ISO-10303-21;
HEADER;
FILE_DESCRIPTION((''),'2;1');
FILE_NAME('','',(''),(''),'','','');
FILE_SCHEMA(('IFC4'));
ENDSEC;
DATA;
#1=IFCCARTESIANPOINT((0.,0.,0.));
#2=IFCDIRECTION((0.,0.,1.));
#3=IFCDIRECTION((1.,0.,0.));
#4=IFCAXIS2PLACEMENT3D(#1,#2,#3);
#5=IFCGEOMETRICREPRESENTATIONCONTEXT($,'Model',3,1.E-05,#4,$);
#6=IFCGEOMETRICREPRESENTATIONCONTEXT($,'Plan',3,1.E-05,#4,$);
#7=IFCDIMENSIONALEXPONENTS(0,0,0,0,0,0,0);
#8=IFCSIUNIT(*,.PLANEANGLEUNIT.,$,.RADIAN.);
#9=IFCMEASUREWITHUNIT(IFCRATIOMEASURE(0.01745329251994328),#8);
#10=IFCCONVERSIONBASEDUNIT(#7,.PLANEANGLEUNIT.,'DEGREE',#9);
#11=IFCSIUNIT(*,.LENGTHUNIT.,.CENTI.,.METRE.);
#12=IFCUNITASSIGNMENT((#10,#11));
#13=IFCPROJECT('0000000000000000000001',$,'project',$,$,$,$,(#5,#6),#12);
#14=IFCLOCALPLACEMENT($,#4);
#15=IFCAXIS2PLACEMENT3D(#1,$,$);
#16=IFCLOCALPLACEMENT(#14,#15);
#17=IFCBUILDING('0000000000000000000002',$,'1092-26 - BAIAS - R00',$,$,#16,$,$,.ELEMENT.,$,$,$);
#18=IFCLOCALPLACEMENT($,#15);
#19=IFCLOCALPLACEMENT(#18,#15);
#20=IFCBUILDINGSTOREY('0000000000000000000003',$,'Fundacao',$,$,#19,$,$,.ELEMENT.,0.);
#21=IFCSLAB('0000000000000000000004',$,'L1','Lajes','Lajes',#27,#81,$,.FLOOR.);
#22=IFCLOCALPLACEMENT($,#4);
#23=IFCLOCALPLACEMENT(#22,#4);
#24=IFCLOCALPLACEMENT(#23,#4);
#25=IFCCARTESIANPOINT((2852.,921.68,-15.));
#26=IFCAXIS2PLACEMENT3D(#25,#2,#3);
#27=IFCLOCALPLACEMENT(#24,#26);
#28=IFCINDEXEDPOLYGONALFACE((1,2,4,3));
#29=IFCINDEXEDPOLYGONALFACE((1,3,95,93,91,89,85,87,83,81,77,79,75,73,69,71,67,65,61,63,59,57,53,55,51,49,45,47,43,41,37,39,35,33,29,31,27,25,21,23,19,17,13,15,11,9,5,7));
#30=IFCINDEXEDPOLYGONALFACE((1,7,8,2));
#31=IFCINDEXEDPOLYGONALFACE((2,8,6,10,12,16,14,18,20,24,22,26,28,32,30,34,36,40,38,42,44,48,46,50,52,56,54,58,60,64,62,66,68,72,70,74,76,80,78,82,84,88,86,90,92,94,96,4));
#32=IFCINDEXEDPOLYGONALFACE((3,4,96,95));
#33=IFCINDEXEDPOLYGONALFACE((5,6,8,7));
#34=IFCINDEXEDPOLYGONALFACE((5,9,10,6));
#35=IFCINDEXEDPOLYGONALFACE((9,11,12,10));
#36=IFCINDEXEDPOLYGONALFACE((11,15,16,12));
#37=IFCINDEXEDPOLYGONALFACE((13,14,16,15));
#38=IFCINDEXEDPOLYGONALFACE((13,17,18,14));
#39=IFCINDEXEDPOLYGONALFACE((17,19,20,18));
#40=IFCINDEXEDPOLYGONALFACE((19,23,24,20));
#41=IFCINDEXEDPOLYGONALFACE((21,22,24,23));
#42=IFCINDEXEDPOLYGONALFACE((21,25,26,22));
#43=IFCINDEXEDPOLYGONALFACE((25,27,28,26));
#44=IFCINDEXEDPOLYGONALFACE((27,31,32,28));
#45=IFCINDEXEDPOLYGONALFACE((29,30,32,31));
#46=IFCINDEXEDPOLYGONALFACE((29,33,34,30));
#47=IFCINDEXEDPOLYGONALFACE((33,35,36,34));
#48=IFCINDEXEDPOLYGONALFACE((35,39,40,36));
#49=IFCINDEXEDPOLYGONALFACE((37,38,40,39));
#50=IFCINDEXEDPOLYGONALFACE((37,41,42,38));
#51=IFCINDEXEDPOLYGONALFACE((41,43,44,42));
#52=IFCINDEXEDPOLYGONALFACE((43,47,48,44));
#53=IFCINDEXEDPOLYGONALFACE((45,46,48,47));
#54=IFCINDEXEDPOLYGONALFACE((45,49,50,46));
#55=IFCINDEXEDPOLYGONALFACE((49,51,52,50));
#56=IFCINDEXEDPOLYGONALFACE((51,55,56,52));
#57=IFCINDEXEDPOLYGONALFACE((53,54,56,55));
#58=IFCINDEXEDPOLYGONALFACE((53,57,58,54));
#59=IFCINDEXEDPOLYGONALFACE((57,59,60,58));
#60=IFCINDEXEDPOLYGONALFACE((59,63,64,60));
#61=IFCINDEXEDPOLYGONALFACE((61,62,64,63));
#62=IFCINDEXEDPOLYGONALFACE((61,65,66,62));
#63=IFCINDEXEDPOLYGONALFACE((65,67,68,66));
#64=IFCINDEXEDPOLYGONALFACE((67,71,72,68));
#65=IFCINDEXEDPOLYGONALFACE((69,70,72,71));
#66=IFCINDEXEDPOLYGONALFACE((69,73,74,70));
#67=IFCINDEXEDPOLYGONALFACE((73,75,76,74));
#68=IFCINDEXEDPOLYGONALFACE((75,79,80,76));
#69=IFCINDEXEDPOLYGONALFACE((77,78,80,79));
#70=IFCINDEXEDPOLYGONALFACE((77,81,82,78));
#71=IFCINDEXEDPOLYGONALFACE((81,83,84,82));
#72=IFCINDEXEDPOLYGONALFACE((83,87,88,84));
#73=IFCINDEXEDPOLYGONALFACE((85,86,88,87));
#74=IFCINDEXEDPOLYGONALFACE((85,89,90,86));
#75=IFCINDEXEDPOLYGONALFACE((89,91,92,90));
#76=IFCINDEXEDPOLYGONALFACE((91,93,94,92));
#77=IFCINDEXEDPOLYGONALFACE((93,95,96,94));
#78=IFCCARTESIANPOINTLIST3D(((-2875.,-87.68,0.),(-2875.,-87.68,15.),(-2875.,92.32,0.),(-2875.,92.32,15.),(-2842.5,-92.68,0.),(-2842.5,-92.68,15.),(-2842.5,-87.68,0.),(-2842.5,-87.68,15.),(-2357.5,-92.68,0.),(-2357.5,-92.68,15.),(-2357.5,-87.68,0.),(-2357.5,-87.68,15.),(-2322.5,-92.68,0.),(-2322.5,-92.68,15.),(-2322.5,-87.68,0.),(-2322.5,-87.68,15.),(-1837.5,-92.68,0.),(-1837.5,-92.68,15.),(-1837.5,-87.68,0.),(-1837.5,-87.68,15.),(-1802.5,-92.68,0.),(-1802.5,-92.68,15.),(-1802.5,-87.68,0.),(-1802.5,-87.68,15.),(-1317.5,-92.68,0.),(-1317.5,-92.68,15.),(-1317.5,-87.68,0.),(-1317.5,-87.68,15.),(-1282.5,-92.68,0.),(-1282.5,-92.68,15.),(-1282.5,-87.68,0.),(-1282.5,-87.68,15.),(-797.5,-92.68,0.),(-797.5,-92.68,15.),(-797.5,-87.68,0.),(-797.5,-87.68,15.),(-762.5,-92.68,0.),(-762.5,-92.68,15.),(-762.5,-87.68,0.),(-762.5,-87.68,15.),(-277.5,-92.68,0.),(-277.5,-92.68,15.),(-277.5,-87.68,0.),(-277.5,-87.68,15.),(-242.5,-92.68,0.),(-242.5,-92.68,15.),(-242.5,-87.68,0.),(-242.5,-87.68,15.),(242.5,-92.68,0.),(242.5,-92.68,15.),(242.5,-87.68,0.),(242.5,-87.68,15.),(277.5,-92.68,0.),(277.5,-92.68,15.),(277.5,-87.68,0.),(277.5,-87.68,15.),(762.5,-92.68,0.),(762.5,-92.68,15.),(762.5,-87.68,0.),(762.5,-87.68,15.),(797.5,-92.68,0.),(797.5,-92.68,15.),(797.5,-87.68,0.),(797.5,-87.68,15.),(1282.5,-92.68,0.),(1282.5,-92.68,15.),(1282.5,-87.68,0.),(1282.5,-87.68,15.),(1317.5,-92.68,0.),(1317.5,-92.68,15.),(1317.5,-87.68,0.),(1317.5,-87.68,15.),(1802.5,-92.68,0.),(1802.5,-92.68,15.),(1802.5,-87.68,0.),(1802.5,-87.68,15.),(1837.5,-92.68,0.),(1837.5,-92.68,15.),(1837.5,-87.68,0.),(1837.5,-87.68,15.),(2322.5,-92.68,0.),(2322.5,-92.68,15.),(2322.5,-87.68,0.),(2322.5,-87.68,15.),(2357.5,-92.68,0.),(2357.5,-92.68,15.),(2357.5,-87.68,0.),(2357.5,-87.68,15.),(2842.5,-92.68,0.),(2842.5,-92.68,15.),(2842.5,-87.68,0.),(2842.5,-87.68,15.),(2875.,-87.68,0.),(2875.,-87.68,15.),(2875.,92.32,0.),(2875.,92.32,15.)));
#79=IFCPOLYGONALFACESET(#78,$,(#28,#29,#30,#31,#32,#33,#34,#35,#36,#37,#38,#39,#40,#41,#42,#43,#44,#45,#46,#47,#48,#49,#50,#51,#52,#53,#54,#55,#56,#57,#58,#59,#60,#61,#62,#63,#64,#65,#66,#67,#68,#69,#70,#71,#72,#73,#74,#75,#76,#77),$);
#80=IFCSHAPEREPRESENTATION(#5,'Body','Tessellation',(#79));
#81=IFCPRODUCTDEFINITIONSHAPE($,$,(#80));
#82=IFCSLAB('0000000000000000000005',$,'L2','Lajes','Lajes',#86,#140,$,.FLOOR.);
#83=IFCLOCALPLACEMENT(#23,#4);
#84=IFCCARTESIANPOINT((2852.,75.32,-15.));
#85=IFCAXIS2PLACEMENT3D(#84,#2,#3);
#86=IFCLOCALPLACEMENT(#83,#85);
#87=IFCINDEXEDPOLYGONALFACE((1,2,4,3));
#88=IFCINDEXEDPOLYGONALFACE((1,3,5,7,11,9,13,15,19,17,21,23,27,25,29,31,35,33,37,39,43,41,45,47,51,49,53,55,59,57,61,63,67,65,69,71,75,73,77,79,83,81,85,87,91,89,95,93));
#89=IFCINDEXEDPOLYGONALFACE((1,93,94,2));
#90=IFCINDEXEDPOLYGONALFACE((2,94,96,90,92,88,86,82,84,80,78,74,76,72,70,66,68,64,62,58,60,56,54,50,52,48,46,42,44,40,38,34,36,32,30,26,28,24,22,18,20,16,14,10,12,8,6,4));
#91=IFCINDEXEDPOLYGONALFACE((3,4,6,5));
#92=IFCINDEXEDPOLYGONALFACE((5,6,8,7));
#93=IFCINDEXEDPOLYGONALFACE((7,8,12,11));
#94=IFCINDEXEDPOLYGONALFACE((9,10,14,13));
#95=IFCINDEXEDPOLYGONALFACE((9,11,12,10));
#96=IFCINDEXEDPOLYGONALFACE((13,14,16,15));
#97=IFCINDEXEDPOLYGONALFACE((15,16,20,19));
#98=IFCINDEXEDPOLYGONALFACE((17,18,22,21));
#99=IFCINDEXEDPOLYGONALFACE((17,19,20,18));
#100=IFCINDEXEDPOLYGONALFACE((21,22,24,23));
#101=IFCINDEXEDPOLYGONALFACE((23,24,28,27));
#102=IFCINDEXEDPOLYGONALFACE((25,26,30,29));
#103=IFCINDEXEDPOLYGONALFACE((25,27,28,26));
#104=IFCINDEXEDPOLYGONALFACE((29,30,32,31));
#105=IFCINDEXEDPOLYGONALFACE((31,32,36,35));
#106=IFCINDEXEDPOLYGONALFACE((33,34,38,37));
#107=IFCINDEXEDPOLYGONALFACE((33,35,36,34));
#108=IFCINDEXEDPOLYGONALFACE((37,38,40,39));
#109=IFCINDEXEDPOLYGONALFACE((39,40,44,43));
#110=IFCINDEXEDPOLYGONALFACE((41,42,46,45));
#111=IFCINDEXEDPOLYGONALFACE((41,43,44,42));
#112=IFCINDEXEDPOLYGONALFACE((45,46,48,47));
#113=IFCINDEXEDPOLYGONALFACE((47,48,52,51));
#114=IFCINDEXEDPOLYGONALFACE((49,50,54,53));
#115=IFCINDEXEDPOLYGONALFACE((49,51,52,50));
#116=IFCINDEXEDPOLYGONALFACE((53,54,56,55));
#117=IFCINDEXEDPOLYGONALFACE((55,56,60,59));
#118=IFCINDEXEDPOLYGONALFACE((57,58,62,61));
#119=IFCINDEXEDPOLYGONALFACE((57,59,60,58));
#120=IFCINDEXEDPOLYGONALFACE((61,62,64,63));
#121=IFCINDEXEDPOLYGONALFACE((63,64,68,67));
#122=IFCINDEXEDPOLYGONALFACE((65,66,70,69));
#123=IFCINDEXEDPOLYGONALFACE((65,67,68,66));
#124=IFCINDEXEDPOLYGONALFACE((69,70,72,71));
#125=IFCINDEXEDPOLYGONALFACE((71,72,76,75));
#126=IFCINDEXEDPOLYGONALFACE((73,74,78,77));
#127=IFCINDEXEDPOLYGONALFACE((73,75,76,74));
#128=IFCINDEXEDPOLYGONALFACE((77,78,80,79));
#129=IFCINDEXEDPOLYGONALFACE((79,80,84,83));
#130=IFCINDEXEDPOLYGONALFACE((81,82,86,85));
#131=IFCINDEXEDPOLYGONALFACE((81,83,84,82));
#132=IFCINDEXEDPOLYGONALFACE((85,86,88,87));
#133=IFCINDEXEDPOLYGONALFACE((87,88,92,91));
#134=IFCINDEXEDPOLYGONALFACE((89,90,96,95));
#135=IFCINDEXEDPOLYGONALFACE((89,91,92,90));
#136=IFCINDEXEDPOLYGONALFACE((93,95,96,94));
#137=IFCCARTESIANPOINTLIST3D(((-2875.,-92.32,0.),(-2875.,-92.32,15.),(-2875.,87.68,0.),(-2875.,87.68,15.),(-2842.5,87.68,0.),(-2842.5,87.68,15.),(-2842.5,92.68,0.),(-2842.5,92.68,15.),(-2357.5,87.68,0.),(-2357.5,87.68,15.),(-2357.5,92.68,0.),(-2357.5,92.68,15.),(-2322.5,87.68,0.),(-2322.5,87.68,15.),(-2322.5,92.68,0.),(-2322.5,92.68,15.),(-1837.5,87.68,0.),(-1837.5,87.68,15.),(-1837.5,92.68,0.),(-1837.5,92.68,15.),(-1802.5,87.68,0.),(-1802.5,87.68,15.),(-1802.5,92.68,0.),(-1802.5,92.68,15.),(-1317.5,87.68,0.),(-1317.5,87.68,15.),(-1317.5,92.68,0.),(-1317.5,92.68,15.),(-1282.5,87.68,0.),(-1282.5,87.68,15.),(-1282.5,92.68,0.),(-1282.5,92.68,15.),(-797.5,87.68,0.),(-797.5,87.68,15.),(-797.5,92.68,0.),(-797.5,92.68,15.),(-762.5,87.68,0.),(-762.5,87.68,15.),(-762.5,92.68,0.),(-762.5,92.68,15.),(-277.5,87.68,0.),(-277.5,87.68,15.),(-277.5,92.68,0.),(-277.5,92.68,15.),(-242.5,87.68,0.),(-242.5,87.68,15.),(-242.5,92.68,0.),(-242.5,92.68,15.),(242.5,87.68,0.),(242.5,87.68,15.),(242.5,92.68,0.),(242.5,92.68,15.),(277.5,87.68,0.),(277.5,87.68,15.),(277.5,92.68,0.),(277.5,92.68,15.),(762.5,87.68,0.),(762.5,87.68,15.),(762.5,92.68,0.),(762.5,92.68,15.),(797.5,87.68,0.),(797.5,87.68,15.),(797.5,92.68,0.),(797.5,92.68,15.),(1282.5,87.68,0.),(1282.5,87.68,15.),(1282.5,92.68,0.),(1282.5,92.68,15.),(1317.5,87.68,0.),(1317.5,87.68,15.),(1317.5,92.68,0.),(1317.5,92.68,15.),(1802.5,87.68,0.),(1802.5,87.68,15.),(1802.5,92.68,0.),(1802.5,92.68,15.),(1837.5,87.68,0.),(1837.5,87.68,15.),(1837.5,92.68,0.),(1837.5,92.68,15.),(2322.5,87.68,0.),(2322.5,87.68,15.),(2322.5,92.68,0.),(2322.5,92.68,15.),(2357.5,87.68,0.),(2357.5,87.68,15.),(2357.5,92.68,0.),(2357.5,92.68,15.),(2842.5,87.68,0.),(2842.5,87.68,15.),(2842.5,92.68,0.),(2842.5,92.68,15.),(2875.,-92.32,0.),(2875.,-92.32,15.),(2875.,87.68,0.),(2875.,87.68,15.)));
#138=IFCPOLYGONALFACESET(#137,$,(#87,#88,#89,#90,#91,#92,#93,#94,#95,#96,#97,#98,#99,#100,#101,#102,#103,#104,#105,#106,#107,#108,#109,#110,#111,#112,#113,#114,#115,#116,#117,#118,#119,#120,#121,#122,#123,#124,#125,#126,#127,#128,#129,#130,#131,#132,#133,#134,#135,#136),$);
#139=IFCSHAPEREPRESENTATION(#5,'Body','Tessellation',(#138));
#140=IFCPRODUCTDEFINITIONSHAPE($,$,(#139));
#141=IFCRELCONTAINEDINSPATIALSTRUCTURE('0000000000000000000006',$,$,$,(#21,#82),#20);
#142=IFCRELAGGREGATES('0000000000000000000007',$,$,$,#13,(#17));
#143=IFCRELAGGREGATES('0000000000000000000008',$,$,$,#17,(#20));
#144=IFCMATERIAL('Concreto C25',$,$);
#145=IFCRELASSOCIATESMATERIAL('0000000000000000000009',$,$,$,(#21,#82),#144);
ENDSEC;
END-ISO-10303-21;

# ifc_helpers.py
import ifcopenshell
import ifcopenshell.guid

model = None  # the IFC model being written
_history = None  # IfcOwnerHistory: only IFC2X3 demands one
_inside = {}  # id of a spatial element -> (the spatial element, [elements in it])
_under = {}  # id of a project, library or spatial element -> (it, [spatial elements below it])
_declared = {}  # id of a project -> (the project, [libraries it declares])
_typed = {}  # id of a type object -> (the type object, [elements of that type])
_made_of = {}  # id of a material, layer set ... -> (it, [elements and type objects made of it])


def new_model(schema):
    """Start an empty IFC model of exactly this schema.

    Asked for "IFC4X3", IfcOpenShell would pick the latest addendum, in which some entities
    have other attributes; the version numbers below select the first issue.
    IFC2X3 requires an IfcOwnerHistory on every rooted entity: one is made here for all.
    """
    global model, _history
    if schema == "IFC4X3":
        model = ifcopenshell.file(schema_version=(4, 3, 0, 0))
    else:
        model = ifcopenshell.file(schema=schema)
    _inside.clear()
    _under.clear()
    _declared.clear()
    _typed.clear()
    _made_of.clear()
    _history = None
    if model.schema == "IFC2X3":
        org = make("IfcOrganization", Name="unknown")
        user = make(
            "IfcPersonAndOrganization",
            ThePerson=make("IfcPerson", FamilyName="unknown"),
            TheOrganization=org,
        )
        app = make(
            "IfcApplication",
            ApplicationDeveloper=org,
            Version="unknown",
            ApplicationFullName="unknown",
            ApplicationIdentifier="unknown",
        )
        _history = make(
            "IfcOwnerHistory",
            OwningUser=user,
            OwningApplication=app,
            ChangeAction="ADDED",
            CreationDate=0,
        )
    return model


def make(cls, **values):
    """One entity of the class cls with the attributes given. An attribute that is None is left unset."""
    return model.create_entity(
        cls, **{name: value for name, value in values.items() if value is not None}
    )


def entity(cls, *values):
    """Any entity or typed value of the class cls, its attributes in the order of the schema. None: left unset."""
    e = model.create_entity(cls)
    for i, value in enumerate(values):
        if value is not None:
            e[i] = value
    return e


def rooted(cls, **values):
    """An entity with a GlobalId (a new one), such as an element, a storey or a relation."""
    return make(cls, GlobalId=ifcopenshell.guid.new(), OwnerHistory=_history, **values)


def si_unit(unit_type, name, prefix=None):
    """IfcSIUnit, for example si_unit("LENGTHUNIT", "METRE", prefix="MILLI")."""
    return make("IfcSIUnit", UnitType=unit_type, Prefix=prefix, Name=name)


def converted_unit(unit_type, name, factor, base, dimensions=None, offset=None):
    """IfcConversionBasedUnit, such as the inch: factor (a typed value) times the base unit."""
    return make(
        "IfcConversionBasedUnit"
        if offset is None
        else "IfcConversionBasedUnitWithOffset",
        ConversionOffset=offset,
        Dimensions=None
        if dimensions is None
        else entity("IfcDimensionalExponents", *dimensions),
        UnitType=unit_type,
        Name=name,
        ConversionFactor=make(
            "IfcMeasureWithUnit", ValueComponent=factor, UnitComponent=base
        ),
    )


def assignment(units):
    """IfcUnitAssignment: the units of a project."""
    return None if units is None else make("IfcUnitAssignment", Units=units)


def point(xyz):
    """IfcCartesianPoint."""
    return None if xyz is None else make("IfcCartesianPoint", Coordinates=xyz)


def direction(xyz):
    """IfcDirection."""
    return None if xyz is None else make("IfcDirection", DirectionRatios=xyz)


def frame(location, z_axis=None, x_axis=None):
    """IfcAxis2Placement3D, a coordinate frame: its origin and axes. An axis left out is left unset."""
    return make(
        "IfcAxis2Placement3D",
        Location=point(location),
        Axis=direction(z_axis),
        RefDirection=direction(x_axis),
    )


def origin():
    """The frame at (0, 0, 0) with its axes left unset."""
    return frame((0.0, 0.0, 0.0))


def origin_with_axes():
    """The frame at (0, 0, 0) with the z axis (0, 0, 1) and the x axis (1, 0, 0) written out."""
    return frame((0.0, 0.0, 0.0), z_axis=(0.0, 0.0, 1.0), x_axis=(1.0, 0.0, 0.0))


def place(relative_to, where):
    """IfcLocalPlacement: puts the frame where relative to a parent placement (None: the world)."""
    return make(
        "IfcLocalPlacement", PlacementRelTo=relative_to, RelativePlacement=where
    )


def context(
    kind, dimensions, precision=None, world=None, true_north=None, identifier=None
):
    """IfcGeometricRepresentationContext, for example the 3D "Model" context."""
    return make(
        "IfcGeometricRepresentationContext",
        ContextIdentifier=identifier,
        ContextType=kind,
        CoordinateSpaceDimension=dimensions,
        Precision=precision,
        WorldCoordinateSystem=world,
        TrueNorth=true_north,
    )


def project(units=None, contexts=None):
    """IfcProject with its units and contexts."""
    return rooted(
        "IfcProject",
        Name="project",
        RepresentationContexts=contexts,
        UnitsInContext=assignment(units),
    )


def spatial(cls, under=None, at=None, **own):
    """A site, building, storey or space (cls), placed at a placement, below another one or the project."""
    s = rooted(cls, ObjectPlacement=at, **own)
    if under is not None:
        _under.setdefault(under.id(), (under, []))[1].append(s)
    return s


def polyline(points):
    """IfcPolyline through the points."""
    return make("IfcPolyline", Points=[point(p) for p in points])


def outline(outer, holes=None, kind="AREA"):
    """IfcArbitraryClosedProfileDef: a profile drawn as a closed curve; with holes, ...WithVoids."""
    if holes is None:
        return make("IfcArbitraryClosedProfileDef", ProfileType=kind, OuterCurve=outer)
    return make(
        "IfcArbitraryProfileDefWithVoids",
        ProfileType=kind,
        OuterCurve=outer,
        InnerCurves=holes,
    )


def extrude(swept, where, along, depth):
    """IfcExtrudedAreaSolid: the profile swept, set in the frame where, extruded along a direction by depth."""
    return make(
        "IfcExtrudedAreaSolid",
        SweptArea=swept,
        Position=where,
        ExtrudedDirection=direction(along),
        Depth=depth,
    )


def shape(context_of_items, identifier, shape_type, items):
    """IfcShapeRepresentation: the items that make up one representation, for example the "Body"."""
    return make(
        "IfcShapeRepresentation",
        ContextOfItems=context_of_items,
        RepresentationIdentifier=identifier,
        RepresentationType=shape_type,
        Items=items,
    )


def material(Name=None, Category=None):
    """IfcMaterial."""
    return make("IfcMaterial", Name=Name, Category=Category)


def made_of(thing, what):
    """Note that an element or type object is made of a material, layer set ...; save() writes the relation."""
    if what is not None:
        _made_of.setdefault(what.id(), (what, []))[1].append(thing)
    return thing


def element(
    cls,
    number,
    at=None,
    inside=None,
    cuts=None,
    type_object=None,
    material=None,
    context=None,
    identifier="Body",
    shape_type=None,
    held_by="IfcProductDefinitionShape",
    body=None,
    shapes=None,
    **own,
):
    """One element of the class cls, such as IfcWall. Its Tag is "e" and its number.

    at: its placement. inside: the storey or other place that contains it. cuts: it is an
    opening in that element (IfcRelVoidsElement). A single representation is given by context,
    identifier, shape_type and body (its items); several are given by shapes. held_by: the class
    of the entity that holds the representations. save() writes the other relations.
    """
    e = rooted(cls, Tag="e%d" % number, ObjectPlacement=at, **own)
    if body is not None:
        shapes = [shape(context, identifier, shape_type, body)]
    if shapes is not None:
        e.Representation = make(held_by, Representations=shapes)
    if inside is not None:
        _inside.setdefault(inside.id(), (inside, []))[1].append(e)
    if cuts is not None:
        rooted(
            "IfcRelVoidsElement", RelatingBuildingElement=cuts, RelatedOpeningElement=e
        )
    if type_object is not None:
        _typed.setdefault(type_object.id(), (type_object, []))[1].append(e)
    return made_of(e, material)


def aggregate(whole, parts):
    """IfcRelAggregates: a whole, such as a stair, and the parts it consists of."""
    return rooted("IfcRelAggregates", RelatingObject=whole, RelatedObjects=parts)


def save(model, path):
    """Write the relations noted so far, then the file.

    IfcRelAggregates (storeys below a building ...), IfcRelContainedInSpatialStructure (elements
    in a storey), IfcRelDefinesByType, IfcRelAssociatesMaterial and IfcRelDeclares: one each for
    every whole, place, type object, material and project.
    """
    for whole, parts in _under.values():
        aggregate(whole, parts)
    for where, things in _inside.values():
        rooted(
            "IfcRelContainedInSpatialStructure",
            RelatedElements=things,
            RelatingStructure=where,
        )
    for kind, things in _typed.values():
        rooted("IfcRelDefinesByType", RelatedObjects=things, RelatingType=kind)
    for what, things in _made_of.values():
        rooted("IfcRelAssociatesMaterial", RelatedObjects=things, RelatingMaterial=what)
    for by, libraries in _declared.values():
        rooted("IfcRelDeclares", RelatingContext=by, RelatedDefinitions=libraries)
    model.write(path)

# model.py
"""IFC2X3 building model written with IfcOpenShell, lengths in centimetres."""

from ifc_helpers import new_model, entity, si_unit, converted_unit, frame, origin, origin_with_axes, place, context, project, spatial, polyline, outline, extrude, material, element, save


model = new_model("IFC2X3")

# Units and contexts
model_context = context("Model", 3, precision=1e-05, world=origin_with_axes())
plan_context = context("Plan", 3, precision=1e-05, world=origin_with_axes())
ifc_project = project(units=[converted_unit("PLANEANGLEUNIT", "DEGREE", entity("IfcRatioMeasure", 0.01745329251994328), si_unit("PLANEANGLEUNIT", "RADIAN"), dimensions=[0, 0, 0, 0, 0, 0, 0]), si_unit("LENGTHUNIT", "METRE", prefix="CENTI")], contexts=[model_context, plan_context])

# Building, storey
placement_1 = place(None, origin_with_axes())
building_placement = place(placement_1, origin())
building = spatial("IfcBuilding", under=ifc_project, at=building_placement, Name="1092-26 - BAIAS - R00", CompositionType="ELEMENT")
placement_2 = place(None, origin())
storey_placement = place(placement_2, origin())
storey = spatial("IfcBuildingStorey", under=building, at=storey_placement, Name="Fundacao", CompositionType="ELEMENT", Elevation=0.0)

# Shared definitions
placement_3 = place(None, origin_with_axes())
placement_4 = place(placement_3, origin_with_axes())

# Slabs
ifc_material_1 = material(Name="Concreto C25")
placement_5 = place(placement_4, origin_with_axes())
slab_1_placement = place(placement_5, frame((2852.0, 921.68, -15.0), z_axis=(0.0, 0.0, 1.0), x_axis=(1.0, 0.0, 0.0)))
element("IfcSlab", 1, at=slab_1_placement, inside=storey, material=ifc_material_1, Name="L1", Description="Lajes", ObjectType="Lajes", PredefinedType="FLOOR", context=model_context, shape_type="SweptSolid", body=[
    extrude(outline(polyline([(-2842.5, -87.68, 0.0), (-2875.0, -87.68, 0.0), (-2875.0, 92.32, 0.0), (2875.0, 92.32, 0.0), (2875.0, -87.68, 0.0), (2842.5, -87.68, 0.0), (2842.5, -92.68, 0.0), (2357.5, -92.68, 0.0), (2357.5, -87.68, 0.0), (2322.5, -87.68, 0.0), (2322.5, -92.68, 0.0), (1837.5, -92.68, 0.0), (1837.5, -87.68, 0.0), (1802.5, -87.68, 0.0), (1802.5, -92.68, 0.0), (1317.5, -92.68, 0.0), (1317.5, -87.68, 0.0), (1282.5, -87.68, 0.0), (1282.5, -92.68, 0.0), (797.5, -92.68, 0.0), (797.5, -87.68, 0.0), (762.5, -87.68, 0.0), (762.5, -92.68, 0.0), (277.5, -92.68, 0.0), (277.5, -87.68, 0.0), (242.5, -87.68, 0.0), (242.5, -92.68, 0.0), (-242.5, -92.68, 0.0), (-242.5, -87.68, 0.0), (-277.5, -87.68, 0.0), (-277.5, -92.68, 0.0), (-762.5, -92.68, 0.0), (-762.5, -87.68, 0.0), (-797.5, -87.68, 0.0), (-797.5, -92.68, 0.0), (-1282.5, -92.68, 0.0), (-1282.5, -87.68, 0.0), (-1317.5, -87.68, 0.0), (-1317.5, -92.68, 0.0), (-1802.5, -92.68, 0.0), (-1802.5, -87.68, 0.0), (-1837.5, -87.68, 0.0), (-1837.5, -92.68, 0.0), (-2322.5, -92.68, 0.0), (-2322.5, -87.68, 0.0), (-2357.5, -87.68, 0.0), (-2357.5, -92.68, 0.0), (-2842.5, -92.68, 0.0), (-2842.5, -87.68, 0.0)])), origin_with_axes(), (0.0, 0.0, 1.0), 15.0),
])
placement_6 = place(placement_4, origin_with_axes())
slab_2_placement = place(placement_6, frame((2852.0, 75.32, -15.0), z_axis=(0.0, 0.0, 1.0), x_axis=(1.0, 0.0, 0.0)))
element("IfcSlab", 2, at=slab_2_placement, inside=storey, material=ifc_material_1, Name="L2", Description="Lajes", ObjectType="Lajes", PredefinedType="FLOOR", context=model_context, shape_type="SweptSolid", body=[
    extrude(outline(polyline([(-2357.5, 87.68, 0.0), (-2322.5, 87.68, 0.0), (-2322.5, 92.68, 0.0), (-1837.5, 92.68, 0.0), (-1837.5, 87.68, 0.0), (-1802.5, 87.68, 0.0), (-1802.5, 92.68, 0.0), (-1317.5, 92.68, 0.0), (-1317.5, 87.68, 0.0), (-1282.5, 87.68, 0.0), (-1282.5, 92.68, 0.0), (-797.5, 92.68, 0.0), (-797.5, 87.68, 0.0), (-762.5, 87.68, 0.0), (-762.5, 92.68, 0.0), (-277.5, 92.68, 0.0), (-277.5, 87.68, 0.0), (-242.5, 87.68, 0.0), (-242.5, 92.68, 0.0), (242.5, 92.68, 0.0), (242.5, 87.68, 0.0), (277.5, 87.68, 0.0), (277.5, 92.68, 0.0), (762.5, 92.68, 0.0), (762.5, 87.68, 0.0), (797.5, 87.68, 0.0), (797.5, 92.68, 0.0), (1282.5, 92.68, 0.0), (1282.5, 87.68, 0.0), (1317.5, 87.68, 0.0), (1317.5, 92.68, 0.0), (1802.5, 92.68, 0.0), (1802.5, 87.68, 0.0), (1837.5, 87.68, 0.0), (1837.5, 92.68, 0.0), (2322.5, 92.68, 0.0), (2322.5, 87.68, 0.0), (2357.5, 87.68, 0.0), (2357.5, 92.68, 0.0), (2842.5, 92.68, 0.0), (2842.5, 87.68, 0.0), (2875.0, 87.68, 0.0), (2875.0, -92.32, 0.0), (-2875.0, -92.32, 0.0), (-2875.0, 87.68, 0.0), (-2842.5, 87.68, 0.0), (-2842.5, 92.68, 0.0), (-2357.5, 92.68, 0.0), (-2357.5, 87.68, 0.0)])), origin_with_axes(), (0.0, 0.0, 1.0), 15.0),
])

save(model, "model.ifc")
